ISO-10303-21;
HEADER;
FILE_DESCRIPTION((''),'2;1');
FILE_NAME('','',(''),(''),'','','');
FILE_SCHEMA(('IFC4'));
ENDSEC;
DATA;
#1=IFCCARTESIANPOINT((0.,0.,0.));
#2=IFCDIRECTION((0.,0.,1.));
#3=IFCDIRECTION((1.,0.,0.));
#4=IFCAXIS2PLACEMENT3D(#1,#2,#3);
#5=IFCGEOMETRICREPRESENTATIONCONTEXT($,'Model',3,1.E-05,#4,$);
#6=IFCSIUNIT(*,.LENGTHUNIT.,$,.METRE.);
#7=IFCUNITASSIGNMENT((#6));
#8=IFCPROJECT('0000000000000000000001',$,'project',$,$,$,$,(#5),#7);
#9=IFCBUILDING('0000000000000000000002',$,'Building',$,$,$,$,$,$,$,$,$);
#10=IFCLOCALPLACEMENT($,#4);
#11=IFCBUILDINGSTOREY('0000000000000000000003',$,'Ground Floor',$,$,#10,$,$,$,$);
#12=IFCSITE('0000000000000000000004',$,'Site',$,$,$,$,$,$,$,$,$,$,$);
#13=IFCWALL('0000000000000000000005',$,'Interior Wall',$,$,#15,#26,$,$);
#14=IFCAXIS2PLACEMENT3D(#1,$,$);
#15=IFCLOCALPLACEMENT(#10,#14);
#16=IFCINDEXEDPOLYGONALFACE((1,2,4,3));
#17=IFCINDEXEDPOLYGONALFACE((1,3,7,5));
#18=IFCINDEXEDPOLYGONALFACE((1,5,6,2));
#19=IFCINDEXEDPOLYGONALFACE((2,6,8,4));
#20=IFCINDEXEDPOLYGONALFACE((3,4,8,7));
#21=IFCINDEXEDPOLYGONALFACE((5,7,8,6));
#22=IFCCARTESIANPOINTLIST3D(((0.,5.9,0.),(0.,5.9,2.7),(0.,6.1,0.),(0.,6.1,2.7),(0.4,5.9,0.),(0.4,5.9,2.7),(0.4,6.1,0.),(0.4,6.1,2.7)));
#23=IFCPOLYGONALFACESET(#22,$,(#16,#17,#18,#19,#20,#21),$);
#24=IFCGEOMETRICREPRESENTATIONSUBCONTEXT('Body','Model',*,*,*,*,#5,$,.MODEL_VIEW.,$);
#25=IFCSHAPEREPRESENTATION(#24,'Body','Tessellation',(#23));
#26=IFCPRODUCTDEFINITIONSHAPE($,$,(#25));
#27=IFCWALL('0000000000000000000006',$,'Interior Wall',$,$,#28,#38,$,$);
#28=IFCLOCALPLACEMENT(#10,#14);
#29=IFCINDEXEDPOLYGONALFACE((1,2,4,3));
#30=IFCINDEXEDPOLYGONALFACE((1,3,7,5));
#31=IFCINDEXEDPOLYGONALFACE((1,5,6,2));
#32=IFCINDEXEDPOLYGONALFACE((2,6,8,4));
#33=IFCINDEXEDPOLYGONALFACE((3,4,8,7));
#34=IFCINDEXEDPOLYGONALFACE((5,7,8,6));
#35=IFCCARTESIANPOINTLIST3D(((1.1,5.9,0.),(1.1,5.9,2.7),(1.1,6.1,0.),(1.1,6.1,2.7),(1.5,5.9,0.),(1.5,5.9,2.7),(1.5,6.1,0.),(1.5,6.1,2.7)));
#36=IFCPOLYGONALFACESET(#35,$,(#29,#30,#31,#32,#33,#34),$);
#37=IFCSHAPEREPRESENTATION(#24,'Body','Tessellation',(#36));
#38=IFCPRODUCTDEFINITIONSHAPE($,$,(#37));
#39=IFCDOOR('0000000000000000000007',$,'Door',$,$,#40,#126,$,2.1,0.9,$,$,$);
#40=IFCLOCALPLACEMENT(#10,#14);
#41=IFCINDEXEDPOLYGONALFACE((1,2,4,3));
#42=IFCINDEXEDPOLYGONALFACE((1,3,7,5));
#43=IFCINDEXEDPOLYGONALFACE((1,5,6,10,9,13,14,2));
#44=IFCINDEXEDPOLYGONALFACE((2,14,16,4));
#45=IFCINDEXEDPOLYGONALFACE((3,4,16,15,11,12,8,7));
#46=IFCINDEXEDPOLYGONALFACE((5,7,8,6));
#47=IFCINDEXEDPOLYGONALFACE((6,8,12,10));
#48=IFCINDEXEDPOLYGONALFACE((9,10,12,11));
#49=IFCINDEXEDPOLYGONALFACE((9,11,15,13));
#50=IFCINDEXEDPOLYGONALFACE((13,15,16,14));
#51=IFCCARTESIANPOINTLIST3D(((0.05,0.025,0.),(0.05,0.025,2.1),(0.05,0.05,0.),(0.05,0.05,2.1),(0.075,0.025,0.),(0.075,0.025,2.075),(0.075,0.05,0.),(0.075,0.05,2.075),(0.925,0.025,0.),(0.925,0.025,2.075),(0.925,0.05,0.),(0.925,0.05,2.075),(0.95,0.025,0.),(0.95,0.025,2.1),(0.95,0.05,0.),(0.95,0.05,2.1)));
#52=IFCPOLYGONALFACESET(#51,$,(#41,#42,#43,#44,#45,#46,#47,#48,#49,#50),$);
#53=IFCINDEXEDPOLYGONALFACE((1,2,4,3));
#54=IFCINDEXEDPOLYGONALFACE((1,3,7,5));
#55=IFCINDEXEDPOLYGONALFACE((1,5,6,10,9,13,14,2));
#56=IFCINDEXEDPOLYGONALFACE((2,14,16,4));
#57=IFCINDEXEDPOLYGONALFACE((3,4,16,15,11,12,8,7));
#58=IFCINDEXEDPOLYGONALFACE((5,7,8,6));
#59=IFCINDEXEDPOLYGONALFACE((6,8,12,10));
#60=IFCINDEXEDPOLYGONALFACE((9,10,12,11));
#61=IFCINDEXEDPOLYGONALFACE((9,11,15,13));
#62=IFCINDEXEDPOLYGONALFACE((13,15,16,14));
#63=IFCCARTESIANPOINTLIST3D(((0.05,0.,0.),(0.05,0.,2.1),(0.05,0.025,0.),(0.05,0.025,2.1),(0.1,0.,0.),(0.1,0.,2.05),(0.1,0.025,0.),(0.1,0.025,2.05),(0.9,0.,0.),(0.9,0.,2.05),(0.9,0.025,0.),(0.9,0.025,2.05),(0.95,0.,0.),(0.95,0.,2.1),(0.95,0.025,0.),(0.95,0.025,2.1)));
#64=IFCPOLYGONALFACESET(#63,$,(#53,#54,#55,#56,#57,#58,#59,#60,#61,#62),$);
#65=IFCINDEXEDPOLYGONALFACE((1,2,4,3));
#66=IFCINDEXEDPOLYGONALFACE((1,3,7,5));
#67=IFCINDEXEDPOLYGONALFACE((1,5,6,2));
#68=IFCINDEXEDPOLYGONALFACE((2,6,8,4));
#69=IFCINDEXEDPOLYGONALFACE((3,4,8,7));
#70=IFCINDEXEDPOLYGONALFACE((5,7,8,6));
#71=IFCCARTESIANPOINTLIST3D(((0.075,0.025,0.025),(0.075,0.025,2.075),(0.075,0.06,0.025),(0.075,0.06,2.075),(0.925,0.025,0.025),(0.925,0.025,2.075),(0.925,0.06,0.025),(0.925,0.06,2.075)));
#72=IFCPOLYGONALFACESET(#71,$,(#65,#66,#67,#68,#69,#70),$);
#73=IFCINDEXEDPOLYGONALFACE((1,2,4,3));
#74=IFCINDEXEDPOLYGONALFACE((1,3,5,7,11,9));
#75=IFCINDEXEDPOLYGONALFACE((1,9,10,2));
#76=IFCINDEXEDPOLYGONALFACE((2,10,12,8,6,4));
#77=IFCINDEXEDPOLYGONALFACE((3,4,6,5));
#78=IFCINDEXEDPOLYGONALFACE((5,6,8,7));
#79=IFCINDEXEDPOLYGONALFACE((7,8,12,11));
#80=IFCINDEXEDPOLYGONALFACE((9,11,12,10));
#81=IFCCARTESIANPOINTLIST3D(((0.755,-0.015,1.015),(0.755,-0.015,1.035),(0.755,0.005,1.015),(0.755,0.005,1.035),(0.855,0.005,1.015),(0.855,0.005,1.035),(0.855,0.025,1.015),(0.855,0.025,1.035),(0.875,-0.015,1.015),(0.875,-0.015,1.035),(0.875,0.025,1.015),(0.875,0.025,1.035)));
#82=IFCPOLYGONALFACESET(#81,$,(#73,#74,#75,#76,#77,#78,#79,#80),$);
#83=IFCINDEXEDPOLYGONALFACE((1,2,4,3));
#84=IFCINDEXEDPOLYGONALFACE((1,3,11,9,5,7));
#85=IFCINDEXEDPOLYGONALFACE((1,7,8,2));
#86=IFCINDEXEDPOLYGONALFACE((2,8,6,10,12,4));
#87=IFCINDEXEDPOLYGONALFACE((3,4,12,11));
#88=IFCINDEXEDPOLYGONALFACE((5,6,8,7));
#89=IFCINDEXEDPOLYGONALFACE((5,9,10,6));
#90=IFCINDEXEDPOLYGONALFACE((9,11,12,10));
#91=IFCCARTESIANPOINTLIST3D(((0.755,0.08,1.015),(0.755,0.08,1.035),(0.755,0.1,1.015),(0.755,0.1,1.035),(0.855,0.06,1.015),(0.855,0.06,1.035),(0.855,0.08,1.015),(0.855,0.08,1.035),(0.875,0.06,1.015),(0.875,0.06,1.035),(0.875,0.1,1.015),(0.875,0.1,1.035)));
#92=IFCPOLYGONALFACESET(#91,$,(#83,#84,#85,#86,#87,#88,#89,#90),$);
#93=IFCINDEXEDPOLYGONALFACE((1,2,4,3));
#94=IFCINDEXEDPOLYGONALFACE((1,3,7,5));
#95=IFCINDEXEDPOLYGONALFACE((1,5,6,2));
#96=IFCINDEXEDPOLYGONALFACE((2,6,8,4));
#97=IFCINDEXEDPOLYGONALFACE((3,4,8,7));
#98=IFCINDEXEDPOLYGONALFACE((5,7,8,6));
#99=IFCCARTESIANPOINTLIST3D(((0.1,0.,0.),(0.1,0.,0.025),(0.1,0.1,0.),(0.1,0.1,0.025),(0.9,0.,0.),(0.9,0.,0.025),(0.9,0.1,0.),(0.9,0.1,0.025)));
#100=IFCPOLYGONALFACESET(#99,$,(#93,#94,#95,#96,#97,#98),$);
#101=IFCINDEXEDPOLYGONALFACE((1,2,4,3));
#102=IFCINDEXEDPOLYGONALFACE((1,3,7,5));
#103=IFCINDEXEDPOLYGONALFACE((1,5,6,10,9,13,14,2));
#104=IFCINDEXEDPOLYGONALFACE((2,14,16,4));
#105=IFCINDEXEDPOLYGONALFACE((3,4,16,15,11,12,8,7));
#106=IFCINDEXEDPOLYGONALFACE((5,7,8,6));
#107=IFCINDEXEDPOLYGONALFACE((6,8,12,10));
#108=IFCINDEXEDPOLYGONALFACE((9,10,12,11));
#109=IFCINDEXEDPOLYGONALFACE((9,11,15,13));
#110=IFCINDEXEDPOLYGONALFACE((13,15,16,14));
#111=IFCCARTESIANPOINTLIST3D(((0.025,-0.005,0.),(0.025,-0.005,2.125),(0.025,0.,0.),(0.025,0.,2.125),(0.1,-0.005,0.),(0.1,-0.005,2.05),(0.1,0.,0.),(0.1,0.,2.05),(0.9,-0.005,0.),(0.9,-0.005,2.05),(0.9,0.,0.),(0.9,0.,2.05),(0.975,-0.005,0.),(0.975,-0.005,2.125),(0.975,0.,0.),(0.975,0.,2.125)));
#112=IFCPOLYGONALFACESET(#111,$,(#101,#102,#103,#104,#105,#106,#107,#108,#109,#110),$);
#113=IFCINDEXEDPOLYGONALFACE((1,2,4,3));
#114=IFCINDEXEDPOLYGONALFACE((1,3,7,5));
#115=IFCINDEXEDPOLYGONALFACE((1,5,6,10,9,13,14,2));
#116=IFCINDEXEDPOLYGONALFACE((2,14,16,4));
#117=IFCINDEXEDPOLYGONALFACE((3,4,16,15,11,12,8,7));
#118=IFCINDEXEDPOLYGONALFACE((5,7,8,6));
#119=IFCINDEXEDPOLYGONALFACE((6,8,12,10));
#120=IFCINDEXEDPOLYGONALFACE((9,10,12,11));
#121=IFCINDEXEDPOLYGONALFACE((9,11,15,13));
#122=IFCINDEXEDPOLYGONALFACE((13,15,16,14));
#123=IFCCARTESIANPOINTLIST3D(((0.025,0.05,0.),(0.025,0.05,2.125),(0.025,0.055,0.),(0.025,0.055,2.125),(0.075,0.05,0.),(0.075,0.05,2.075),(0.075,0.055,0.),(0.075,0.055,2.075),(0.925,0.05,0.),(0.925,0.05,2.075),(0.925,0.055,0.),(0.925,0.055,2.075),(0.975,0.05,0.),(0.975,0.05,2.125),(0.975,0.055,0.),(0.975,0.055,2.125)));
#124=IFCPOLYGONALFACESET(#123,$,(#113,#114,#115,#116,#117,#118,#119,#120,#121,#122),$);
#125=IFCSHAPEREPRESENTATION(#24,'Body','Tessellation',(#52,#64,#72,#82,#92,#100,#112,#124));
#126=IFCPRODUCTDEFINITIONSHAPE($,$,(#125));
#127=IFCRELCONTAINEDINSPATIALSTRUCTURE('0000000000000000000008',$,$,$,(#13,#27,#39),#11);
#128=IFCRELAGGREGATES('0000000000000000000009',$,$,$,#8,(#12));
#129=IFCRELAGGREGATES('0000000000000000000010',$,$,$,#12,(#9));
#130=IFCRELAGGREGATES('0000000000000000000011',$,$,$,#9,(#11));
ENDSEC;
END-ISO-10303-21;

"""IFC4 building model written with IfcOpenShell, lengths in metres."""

from ifc_helpers import new_model, si_unit, frame, origin_with_axes, place, context, subcontext, project, spatial, line, indexed_curve, outline, extrude, element, save


model = new_model("IFC4")

# Units and contexts
model_context = context("Model", 3, precision=1e-05, world=origin_with_axes())
body_context = subcontext(model_context, "Body", "Model", "MODEL_VIEW")
ifc_project = project(units=[si_unit("LENGTHUNIT", "METRE")], contexts=[model_context])

# Site, building, storey
site = spatial("IfcSite", under=ifc_project, Name="Site")
building = spatial("IfcBuilding", under=site, Name="Building")
storey_placement = place(None, origin_with_axes())
storey = spatial("IfcBuildingStorey", under=building, at=storey_placement, Name="Ground Floor")

# Walls
wall_1_placement = place(storey_placement, frame((0.0, 6.0, 0.0), z_axis=(0.0, 0.0, 1.0), x_axis=(1.0, 0.0, 0.0)))
element("IfcWall", 1, at=wall_1_placement, inside=storey, Name="Interior Wall", context=body_context, shape_type="SweptSolid", body=[
    extrude(outline(indexed_curve([(0.0, 0.0), (0.0, 0.2), (0.4, 0.2), (0.4, 0.0), (0.0, 0.0)], self_intersect=False)), frame((0.0, -0.1, 0.0), z_axis=(0.0, 0.0, 1.0), x_axis=(1.0, 0.0, 0.0)), (0.0, 0.0, 1.0), 2.7),
])
wall_2_placement = place(storey_placement, frame((1.1, 6.0, 0.0), z_axis=(0.0, 0.0, 1.0), x_axis=(1.0, 0.0, 0.0)))
element("IfcWall", 2, at=wall_2_placement, inside=storey, Name="Interior Wall", context=body_context, shape_type="SweptSolid", body=[
    extrude(outline(indexed_curve([(0.0, 0.0), (0.0, 0.2), (0.4, 0.2), (0.4, 0.0), (0.0, 0.0)], self_intersect=False)), frame((0.0, -0.1, 0.0), z_axis=(0.0, 0.0, 1.0), x_axis=(1.0, 0.0, 0.0)), (0.0, 0.0, 1.0), 2.7),
])

# Door
door_1_placement = place(storey_placement, frame((0.05, 0.0, 0.0), z_axis=(0.0, 0.0, 1.0), x_axis=(1.0, 0.0, 0.0)))
element("IfcDoor", 3, at=door_1_placement, inside=storey, Name="Door", OverallHeight=2.1, OverallWidth=0.9, context=body_context, shape_type="SweptSolid", body=[
    extrude(outline(indexed_curve([(0.0, 0.0), (0.0, 2.1), (0.9, 2.1), (0.9, 0.0), (0.875, 0.0), (0.875, 2.075), (0.025, 2.075), (0.025, 0.0)], segments=[line(1, 2, 3, 4, 5, 6, 7, 8, 1)])), frame((0.0, 0.025, 0.0), z_axis=(0.0, -1.0, 0.0), x_axis=(1.0, 0.0, 0.0)), (0.0, 0.0, -1.0), 0.025),
    extrude(outline(indexed_curve([(0.0, 0.0), (0.0, 2.1), (0.9, 2.1), (0.9, 0.0), (0.85, 0.0), (0.85, 2.05), (0.05, 2.05), (0.05, 0.0)], segments=[line(1, 2, 3, 4, 5, 6, 7, 8, 1)])), frame((0.0, 0.0, 0.0), z_axis=(0.0, -1.0, 0.0), x_axis=(1.0, 0.0, 0.0)), (0.0, 0.0, -1.0), 0.025),
    extrude(outline(indexed_curve([(0.0, 0.0), (0.85, 0.0), (0.85, 0.035), (0.0, 0.035)], segments=[line(1, 2, 3, 4, 1)])), frame((0.025, 0.025, 0.025), z_axis=(0.0, 0.0, 1.0), x_axis=(1.0, 0.0, 0.0)), (0.0, 0.0, 1.0), 2.05),
    extrude(outline(indexed_curve([(0.0, 0.0), (0.0, -0.04), (-0.12, -0.04), (-0.12, -0.02), (-0.02, -0.02), (-0.02, 0.0)], segments=[line(1, 2, 3, 4, 5, 6, 1)])), frame((0.825, 0.025, 1.015), z_axis=(0.0, 0.0, 1.0), x_axis=(1.0, 0.0, 0.0)), (0.0, 0.0, 1.0), 0.02),
    extrude(outline(indexed_curve([(0.0, 0.0), (0.0, 0.04), (-0.12, 0.04), (-0.12, 0.02), (-0.02, 0.02), (-0.02, 0.0)], segments=[line(1, 2, 3, 4, 5, 6, 1)])), frame((0.825, 0.06, 1.015), z_axis=(0.0, 0.0, 1.0), x_axis=(1.0, 0.0, 0.0)), (0.0, 0.0, 1.0), 0.02),
    extrude(outline(indexed_curve([(0.0, 0.0), (0.8, 0.0), (0.8, 0.1), (0.0, 0.1)], segments=[line(1, 2, 3, 4, 1)])), frame((0.05, 0.0, 0.0), z_axis=(0.0, 0.0, 1.0), x_axis=(1.0, 0.0, 0.0)), (0.0, 0.0, 1.0), 0.025),
    extrude(outline(indexed_curve([(0.0, 0.0), (0.0, 2.125), (0.95, 2.125), (0.95, 0.0), (0.875, 0.0), (0.875, 2.05), (0.075, 2.05), (0.075, 0.0)], segments=[line(1, 2, 3, 4, 5, 6, 7, 8, 1)])), frame((-0.025, -0.005, 0.0), z_axis=(0.0, -1.0, 0.0), x_axis=(1.0, 0.0, 0.0)), (0.0, 0.0, -1.0), 0.005),
    extrude(outline(indexed_curve([(0.0, 0.0), (0.0, 2.125), (0.95, 2.125), (0.95, 0.0), (0.9, 0.0), (0.9, 2.075), (0.05, 2.075), (0.05, 0.0)], segments=[line(1, 2, 3, 4, 5, 6, 7, 8, 1)])), frame((-0.025, 0.05, 0.0), z_axis=(0.0, -1.0, 0.0), x_axis=(1.0, 0.0, 0.0)), (0.0, 0.0, -1.0), 0.005),
])

save(model, "model.ifc")
